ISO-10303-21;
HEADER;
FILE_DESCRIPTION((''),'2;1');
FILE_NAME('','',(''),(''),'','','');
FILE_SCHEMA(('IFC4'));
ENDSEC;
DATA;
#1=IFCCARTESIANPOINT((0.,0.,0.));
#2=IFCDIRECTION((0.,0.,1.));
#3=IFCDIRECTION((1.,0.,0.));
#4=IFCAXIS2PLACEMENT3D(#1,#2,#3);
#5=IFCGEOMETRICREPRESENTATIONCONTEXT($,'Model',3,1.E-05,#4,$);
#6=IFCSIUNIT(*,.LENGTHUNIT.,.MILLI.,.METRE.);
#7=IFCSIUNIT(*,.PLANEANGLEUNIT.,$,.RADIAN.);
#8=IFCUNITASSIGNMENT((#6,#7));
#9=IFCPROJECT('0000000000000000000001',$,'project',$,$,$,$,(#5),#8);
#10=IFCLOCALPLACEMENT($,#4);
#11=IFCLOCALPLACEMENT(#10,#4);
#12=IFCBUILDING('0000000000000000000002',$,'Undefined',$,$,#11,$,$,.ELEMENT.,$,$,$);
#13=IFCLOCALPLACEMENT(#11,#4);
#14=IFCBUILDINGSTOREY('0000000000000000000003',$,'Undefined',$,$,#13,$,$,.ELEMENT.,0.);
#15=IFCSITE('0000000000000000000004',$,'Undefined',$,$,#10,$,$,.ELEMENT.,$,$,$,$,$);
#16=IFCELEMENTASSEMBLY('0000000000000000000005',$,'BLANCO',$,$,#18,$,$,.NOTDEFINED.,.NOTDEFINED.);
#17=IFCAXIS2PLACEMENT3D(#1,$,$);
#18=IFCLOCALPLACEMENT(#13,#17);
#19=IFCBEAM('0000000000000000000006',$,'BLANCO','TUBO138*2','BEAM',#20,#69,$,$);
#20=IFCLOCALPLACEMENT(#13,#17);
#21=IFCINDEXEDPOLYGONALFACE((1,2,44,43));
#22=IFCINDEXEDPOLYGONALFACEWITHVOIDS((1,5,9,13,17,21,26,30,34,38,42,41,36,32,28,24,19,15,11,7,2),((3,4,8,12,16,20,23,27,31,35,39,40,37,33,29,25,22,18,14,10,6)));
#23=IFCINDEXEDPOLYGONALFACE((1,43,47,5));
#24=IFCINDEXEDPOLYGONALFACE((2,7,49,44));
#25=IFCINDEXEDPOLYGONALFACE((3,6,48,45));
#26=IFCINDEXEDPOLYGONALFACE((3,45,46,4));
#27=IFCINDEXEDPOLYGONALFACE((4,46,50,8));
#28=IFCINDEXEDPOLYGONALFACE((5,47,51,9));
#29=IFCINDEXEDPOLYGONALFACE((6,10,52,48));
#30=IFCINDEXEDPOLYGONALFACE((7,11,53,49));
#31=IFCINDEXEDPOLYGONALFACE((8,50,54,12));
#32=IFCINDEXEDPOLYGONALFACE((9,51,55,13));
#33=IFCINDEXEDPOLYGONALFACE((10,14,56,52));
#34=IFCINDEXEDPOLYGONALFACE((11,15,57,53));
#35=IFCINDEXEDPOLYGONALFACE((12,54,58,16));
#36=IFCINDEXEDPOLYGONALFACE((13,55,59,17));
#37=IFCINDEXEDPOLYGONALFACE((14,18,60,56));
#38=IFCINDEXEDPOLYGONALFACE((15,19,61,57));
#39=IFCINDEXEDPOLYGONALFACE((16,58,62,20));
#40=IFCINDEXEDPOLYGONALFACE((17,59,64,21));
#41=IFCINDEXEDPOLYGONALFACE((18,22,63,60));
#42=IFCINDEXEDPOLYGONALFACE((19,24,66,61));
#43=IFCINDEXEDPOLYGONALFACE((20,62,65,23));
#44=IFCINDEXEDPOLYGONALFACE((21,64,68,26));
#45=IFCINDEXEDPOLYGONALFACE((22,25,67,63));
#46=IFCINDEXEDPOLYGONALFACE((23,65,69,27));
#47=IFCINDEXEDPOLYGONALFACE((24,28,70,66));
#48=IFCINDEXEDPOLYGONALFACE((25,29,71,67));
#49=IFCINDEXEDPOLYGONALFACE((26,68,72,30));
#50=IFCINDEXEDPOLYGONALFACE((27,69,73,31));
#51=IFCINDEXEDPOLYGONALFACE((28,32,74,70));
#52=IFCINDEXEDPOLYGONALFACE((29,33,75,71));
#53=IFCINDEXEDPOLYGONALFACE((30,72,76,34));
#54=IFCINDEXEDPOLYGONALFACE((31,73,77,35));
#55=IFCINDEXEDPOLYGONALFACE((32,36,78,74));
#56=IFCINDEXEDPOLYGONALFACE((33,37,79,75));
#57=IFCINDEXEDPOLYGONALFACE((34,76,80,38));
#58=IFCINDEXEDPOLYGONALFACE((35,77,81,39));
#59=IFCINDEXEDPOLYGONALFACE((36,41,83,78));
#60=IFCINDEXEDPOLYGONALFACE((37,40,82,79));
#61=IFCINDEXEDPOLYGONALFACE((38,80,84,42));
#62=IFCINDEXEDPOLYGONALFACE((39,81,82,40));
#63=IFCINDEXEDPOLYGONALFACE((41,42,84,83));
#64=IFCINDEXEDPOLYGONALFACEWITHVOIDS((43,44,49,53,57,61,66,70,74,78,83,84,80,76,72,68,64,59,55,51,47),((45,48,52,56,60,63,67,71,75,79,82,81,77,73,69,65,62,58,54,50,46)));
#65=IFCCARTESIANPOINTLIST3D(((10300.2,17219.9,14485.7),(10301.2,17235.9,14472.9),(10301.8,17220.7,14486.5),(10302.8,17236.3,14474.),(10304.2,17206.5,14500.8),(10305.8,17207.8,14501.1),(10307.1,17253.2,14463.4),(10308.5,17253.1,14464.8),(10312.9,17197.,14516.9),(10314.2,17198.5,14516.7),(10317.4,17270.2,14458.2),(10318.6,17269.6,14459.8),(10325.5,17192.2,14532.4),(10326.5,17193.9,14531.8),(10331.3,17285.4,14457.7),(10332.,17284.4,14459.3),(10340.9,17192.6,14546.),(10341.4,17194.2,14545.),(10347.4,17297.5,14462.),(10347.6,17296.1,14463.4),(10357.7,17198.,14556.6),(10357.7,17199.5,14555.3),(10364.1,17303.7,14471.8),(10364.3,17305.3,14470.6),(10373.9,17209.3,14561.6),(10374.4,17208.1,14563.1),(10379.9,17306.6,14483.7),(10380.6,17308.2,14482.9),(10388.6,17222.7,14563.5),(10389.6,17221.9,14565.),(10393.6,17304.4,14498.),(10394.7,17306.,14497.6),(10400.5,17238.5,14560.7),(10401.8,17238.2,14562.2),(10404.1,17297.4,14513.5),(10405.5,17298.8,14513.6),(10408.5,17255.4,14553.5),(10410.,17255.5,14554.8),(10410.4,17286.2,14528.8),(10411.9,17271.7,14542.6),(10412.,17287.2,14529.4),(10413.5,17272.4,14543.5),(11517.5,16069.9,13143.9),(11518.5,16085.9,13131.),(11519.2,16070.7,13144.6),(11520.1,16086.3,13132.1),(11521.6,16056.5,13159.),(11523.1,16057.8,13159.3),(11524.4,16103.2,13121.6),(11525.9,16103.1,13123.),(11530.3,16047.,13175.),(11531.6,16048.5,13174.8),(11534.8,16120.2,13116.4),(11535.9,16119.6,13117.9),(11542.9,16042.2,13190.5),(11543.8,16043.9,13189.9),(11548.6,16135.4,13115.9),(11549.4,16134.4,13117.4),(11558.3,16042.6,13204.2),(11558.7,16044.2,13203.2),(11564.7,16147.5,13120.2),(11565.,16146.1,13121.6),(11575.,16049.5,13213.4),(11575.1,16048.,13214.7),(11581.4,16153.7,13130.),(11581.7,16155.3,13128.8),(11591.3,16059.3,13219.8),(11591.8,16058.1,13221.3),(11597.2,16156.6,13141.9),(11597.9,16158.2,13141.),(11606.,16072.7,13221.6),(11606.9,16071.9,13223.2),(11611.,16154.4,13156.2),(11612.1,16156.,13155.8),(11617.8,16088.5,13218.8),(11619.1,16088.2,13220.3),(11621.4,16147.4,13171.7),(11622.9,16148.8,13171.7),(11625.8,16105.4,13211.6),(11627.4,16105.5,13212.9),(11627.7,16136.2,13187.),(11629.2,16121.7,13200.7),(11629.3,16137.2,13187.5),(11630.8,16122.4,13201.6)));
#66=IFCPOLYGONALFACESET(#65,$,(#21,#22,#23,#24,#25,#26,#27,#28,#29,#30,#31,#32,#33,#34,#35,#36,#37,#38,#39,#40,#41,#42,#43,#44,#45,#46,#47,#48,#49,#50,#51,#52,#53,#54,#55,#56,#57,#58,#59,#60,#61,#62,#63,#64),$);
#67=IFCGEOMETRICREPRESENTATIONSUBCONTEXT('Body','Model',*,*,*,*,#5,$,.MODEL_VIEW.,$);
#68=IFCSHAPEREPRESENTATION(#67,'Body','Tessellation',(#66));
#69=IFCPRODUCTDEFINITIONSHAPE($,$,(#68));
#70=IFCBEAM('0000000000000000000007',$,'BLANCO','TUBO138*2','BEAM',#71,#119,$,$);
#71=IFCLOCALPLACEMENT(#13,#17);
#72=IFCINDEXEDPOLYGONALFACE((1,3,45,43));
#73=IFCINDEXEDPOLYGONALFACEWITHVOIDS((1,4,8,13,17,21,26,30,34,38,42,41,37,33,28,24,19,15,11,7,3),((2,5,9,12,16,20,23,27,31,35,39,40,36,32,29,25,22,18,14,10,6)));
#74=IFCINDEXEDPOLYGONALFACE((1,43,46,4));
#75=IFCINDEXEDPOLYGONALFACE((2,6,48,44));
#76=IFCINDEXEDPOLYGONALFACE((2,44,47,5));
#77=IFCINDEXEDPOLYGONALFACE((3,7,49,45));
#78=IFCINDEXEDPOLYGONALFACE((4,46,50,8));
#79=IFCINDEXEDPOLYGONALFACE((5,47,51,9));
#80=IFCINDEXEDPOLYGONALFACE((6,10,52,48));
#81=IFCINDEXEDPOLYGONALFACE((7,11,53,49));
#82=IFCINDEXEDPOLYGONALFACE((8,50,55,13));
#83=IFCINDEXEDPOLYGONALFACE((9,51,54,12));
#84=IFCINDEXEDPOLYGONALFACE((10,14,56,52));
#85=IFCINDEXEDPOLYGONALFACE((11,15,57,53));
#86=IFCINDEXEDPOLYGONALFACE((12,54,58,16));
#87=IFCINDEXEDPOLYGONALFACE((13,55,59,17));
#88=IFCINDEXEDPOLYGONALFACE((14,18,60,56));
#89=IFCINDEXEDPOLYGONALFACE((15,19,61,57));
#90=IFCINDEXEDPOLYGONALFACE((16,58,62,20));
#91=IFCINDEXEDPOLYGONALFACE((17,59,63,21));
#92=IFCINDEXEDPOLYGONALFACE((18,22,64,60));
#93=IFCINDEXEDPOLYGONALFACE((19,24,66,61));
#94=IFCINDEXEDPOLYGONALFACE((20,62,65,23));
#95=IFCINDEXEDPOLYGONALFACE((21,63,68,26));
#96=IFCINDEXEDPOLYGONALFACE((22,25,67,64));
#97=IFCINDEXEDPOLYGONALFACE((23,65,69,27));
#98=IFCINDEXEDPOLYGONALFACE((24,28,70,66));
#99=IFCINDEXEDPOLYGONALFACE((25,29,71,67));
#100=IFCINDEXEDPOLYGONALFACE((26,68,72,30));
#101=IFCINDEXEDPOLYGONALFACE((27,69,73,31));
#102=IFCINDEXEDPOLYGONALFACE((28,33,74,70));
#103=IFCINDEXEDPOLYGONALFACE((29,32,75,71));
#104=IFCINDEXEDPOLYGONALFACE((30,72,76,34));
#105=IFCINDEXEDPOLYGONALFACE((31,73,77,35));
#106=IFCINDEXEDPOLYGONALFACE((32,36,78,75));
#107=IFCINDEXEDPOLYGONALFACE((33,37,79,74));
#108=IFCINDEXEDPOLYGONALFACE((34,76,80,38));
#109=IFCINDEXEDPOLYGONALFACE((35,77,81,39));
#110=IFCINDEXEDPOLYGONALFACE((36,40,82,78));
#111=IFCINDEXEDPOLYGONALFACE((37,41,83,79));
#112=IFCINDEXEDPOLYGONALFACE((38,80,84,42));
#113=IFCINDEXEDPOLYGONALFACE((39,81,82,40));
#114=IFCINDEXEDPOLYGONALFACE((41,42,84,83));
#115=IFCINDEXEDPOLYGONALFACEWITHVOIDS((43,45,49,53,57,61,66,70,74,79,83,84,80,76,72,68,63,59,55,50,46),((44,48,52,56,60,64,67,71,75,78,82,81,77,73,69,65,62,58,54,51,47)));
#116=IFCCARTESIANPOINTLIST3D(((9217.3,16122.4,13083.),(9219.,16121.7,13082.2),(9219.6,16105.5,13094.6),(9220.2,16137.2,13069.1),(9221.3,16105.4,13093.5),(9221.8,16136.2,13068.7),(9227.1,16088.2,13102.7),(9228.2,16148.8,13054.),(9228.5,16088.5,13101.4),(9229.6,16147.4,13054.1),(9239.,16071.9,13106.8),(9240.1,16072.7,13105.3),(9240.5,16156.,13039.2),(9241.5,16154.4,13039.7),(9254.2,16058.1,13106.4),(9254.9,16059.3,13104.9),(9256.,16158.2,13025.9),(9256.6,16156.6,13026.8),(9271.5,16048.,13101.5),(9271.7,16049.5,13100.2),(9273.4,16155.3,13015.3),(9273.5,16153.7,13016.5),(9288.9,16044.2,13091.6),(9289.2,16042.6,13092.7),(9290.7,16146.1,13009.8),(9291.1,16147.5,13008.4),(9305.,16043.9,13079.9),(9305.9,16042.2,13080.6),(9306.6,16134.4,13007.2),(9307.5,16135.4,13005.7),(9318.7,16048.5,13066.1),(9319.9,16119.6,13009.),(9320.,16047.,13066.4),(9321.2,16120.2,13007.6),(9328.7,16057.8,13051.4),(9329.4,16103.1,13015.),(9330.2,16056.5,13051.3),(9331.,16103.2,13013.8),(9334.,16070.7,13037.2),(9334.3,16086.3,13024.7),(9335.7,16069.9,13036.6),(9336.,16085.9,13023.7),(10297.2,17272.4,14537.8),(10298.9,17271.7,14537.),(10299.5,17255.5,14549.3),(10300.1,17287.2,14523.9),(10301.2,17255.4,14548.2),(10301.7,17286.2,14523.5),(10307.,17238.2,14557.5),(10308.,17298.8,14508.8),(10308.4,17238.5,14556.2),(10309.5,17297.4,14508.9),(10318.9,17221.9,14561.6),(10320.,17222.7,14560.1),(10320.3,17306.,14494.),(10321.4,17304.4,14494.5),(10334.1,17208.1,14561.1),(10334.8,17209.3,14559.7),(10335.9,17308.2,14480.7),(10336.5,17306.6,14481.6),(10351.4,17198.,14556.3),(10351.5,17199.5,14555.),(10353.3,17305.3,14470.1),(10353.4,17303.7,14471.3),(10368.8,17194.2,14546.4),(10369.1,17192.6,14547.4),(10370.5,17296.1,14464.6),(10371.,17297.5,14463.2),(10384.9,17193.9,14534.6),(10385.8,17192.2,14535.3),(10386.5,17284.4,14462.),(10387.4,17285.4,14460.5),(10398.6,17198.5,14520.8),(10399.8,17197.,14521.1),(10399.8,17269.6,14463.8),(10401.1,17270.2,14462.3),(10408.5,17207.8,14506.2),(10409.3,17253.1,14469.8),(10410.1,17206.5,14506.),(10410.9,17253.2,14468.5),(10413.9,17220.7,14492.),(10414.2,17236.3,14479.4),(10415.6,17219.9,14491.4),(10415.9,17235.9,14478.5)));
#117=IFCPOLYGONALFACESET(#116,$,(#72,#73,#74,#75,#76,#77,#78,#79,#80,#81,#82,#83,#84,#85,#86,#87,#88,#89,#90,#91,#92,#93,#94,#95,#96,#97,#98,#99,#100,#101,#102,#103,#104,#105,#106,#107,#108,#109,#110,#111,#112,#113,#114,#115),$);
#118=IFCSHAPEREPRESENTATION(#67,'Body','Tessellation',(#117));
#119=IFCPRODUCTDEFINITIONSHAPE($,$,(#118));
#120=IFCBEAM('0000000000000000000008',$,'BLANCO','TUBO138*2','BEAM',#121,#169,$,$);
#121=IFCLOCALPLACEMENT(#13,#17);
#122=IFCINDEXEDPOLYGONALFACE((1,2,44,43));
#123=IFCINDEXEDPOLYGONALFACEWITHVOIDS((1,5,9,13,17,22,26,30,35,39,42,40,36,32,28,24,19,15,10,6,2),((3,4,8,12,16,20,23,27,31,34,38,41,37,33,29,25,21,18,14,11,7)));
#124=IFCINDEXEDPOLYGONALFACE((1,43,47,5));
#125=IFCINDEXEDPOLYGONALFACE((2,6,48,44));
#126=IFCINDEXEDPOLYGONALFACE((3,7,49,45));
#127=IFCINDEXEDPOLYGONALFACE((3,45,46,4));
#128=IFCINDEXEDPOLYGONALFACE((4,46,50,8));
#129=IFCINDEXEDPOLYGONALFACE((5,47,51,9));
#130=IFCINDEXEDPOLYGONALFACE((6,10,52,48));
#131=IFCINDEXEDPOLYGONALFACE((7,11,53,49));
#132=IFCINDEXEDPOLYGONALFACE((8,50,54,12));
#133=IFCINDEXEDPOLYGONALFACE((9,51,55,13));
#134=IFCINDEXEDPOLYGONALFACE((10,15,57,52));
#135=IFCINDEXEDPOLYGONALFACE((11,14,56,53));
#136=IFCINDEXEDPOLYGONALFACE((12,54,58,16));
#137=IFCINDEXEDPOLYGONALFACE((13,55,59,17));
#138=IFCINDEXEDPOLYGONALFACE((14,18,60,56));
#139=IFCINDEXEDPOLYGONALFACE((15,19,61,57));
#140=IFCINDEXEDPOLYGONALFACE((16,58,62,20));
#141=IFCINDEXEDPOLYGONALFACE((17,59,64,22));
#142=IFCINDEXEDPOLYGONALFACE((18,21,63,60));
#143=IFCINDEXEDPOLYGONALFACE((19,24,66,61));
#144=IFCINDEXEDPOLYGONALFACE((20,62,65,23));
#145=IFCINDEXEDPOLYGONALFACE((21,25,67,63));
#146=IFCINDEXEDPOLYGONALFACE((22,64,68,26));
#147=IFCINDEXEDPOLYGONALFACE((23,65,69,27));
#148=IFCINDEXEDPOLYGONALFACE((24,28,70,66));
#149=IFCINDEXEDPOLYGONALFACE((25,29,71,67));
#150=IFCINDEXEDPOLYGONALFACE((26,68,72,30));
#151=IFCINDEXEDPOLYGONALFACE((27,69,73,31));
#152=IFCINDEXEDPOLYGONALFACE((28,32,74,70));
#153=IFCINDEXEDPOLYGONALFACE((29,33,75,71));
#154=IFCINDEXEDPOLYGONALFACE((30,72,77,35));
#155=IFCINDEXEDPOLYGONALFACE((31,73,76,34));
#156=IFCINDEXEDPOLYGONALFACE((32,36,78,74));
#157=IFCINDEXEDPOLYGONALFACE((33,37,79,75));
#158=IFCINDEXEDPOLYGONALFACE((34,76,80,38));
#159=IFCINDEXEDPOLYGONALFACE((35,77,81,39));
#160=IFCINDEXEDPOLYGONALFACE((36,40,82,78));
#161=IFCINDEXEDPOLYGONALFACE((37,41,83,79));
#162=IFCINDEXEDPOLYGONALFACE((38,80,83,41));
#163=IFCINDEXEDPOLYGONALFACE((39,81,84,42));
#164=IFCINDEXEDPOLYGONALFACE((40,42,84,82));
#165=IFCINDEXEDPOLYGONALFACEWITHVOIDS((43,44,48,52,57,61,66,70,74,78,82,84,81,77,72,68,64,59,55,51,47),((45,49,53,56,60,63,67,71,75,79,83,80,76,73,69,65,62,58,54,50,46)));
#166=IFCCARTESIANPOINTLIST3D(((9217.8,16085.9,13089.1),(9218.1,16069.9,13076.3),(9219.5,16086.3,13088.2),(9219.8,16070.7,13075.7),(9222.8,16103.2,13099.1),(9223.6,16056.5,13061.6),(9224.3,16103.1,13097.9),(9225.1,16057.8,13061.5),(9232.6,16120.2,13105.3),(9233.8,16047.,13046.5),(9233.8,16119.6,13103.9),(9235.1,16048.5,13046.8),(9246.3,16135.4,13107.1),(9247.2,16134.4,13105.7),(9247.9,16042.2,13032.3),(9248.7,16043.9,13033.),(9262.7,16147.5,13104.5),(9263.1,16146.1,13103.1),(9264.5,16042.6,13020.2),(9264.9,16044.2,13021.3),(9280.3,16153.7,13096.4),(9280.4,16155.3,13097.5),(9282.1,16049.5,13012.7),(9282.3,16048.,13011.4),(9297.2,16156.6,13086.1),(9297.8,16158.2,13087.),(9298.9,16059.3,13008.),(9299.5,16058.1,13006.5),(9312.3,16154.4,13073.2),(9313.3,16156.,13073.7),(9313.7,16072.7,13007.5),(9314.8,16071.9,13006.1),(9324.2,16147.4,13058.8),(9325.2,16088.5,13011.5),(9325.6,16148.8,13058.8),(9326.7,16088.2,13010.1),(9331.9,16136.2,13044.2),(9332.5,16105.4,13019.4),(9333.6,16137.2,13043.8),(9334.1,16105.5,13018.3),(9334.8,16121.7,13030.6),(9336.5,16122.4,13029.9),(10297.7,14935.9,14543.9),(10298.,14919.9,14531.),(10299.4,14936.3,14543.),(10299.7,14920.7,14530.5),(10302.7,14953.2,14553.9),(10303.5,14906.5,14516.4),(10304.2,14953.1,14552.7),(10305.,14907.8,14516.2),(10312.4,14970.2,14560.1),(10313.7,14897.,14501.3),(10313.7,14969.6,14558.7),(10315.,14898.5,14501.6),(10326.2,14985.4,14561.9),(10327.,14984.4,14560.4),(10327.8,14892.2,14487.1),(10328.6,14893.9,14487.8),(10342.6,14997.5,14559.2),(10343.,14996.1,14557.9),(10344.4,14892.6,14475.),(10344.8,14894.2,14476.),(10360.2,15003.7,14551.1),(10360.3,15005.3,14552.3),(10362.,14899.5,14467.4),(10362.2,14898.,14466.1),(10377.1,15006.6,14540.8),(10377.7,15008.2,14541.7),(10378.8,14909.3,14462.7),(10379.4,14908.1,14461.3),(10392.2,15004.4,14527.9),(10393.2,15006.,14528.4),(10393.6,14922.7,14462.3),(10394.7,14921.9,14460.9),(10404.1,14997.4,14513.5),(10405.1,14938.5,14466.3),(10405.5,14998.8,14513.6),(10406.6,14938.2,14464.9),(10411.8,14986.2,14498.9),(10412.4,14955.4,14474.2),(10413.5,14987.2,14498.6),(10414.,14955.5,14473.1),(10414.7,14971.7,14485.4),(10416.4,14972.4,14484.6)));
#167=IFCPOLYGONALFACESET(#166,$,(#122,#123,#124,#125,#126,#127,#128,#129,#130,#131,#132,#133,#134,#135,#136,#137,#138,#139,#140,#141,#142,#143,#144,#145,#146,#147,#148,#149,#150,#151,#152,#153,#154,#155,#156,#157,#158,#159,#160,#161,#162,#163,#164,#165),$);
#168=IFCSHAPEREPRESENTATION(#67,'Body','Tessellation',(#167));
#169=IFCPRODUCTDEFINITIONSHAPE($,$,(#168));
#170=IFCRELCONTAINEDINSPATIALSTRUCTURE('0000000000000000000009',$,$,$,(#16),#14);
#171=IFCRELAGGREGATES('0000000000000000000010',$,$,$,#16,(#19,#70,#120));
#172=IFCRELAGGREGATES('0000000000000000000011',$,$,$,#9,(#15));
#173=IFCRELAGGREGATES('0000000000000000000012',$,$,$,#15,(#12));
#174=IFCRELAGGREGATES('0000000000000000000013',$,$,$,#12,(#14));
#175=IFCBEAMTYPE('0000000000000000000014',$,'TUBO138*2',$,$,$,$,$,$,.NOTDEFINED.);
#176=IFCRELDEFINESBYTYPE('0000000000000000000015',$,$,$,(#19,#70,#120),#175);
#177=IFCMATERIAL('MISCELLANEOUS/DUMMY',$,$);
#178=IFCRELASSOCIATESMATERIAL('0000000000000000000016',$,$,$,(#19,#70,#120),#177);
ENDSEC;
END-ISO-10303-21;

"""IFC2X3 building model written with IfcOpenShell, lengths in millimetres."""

from ifc_helpers import new_model, si_unit, frame, origin_with_axes, origin_2d_with_axis, place, context, subcontext, project, spatial, hollow_circle, extrude, material, type_object, element, aggregate, save


model = new_model("IFC2X3")

# Units and contexts
model_context = context("Model", 3, precision=1e-05, world=origin_with_axes())
body_context = subcontext(model_context, "Body", "Model", "MODEL_VIEW")
ifc_project = project(units=[si_unit("LENGTHUNIT", "METRE", prefix="MILLI"), si_unit("PLANEANGLEUNIT", "RADIAN")], contexts=[model_context])

# Site, building, storey
site_placement = place(None, origin_with_axes())
site = spatial("IfcSite", under=ifc_project, at=site_placement, Name="Undefined", CompositionType="ELEMENT")
building_placement = place(site_placement, origin_with_axes())
building = spatial("IfcBuilding", under=site, at=building_placement, Name="Undefined", CompositionType="ELEMENT")
storey_placement = place(building_placement, origin_with_axes())
storey = spatial("IfcBuildingStorey", under=building, at=storey_placement, Name="Undefined", CompositionType="ELEMENT", Elevation=0.0)

# Element assembly, beams
assembly_placement = place(storey_placement, origin_with_axes())
assembly = element("IfcElementAssembly", 1, at=assembly_placement, inside=storey, Name="BLANCO", AssemblyPlace="NOTDEFINED", PredefinedType="NOTDEFINED")
ifc_material = material(Name="MISCELLANEOUS/DUMMY")
beam_type = type_object("IfcBeamType", Name="TUBO138*2", PredefinedType="NOTDEFINED")
beam_1_placement = place(assembly_placement, frame((10356.8, 17250.0, 14511.2), z_axis=(-0.423552, 0.461316, -0.77961), x_axis=(0.567282, -0.535899, -0.625303)))
beam_1 = element("IfcBeam", 2, at=beam_1_placement, type_object=beam_type, material=ifc_material, Name="BLANCO", Description="TUBO138*2", ObjectType="BEAM", context=body_context, shape_type="SweptSolid", body=[
    extrude(hollow_circle(Radius=69.0, WallThickness=2.0, at=origin_2d_with_axis()), frame((2145.9, 0.0, 0.0), z_axis=(-1.0, 0.0, 0.0), x_axis=(0.0, -1.0, 0.0)), (0.0, 0.0, 1.0), 2145.9),
])
beam_2_placement = place(assembly_placement, frame((9276.9, 16100.0, 13056.4), z_axis=(0.497966, 0.461316, -0.734314), x_axis=(0.503224, 0.535899, 0.677922)))
beam_2 = element("IfcBeam", 3, at=beam_2_placement, type_object=beam_type, material=ifc_material, Name="BLANCO", Description="TUBO138*2", ObjectType="BEAM", context=body_context, shape_type="SweptSolid", body=[
    extrude(hollow_circle(Radius=69.0, WallThickness=2.0, at=origin_2d_with_axis()), frame((2145.9, 0.0, 0.0), z_axis=(-1.0, 0.0, 0.0), x_axis=(0.0, -1.0, 0.0)), (0.0, 0.0, 1.0), 2145.9),
])
beam_3_placement = place(assembly_placement, frame((9276.9, 16100.0, 13056.4), z_axis=(0.497966, -0.461316, -0.734314), x_axis=(0.503224, -0.535899, 0.677922)))
beam_3 = element("IfcBeam", 4, at=beam_3_placement, type_object=beam_type, material=ifc_material, Name="BLANCO", Description="TUBO138*2", ObjectType="BEAM", context=body_context, shape_type="SweptSolid", body=[
    extrude(hollow_circle(Radius=69.0, WallThickness=2.0, at=origin_2d_with_axis()), frame((2145.9, 0.0, 0.0), z_axis=(-1.0, 0.0, 0.0), x_axis=(0.0, -1.0, 0.0)), (0.0, 0.0, 1.0), 2145.9),
])
aggregate(assembly, [beam_1, beam_2, beam_3])

save(model, "model.ifc")
